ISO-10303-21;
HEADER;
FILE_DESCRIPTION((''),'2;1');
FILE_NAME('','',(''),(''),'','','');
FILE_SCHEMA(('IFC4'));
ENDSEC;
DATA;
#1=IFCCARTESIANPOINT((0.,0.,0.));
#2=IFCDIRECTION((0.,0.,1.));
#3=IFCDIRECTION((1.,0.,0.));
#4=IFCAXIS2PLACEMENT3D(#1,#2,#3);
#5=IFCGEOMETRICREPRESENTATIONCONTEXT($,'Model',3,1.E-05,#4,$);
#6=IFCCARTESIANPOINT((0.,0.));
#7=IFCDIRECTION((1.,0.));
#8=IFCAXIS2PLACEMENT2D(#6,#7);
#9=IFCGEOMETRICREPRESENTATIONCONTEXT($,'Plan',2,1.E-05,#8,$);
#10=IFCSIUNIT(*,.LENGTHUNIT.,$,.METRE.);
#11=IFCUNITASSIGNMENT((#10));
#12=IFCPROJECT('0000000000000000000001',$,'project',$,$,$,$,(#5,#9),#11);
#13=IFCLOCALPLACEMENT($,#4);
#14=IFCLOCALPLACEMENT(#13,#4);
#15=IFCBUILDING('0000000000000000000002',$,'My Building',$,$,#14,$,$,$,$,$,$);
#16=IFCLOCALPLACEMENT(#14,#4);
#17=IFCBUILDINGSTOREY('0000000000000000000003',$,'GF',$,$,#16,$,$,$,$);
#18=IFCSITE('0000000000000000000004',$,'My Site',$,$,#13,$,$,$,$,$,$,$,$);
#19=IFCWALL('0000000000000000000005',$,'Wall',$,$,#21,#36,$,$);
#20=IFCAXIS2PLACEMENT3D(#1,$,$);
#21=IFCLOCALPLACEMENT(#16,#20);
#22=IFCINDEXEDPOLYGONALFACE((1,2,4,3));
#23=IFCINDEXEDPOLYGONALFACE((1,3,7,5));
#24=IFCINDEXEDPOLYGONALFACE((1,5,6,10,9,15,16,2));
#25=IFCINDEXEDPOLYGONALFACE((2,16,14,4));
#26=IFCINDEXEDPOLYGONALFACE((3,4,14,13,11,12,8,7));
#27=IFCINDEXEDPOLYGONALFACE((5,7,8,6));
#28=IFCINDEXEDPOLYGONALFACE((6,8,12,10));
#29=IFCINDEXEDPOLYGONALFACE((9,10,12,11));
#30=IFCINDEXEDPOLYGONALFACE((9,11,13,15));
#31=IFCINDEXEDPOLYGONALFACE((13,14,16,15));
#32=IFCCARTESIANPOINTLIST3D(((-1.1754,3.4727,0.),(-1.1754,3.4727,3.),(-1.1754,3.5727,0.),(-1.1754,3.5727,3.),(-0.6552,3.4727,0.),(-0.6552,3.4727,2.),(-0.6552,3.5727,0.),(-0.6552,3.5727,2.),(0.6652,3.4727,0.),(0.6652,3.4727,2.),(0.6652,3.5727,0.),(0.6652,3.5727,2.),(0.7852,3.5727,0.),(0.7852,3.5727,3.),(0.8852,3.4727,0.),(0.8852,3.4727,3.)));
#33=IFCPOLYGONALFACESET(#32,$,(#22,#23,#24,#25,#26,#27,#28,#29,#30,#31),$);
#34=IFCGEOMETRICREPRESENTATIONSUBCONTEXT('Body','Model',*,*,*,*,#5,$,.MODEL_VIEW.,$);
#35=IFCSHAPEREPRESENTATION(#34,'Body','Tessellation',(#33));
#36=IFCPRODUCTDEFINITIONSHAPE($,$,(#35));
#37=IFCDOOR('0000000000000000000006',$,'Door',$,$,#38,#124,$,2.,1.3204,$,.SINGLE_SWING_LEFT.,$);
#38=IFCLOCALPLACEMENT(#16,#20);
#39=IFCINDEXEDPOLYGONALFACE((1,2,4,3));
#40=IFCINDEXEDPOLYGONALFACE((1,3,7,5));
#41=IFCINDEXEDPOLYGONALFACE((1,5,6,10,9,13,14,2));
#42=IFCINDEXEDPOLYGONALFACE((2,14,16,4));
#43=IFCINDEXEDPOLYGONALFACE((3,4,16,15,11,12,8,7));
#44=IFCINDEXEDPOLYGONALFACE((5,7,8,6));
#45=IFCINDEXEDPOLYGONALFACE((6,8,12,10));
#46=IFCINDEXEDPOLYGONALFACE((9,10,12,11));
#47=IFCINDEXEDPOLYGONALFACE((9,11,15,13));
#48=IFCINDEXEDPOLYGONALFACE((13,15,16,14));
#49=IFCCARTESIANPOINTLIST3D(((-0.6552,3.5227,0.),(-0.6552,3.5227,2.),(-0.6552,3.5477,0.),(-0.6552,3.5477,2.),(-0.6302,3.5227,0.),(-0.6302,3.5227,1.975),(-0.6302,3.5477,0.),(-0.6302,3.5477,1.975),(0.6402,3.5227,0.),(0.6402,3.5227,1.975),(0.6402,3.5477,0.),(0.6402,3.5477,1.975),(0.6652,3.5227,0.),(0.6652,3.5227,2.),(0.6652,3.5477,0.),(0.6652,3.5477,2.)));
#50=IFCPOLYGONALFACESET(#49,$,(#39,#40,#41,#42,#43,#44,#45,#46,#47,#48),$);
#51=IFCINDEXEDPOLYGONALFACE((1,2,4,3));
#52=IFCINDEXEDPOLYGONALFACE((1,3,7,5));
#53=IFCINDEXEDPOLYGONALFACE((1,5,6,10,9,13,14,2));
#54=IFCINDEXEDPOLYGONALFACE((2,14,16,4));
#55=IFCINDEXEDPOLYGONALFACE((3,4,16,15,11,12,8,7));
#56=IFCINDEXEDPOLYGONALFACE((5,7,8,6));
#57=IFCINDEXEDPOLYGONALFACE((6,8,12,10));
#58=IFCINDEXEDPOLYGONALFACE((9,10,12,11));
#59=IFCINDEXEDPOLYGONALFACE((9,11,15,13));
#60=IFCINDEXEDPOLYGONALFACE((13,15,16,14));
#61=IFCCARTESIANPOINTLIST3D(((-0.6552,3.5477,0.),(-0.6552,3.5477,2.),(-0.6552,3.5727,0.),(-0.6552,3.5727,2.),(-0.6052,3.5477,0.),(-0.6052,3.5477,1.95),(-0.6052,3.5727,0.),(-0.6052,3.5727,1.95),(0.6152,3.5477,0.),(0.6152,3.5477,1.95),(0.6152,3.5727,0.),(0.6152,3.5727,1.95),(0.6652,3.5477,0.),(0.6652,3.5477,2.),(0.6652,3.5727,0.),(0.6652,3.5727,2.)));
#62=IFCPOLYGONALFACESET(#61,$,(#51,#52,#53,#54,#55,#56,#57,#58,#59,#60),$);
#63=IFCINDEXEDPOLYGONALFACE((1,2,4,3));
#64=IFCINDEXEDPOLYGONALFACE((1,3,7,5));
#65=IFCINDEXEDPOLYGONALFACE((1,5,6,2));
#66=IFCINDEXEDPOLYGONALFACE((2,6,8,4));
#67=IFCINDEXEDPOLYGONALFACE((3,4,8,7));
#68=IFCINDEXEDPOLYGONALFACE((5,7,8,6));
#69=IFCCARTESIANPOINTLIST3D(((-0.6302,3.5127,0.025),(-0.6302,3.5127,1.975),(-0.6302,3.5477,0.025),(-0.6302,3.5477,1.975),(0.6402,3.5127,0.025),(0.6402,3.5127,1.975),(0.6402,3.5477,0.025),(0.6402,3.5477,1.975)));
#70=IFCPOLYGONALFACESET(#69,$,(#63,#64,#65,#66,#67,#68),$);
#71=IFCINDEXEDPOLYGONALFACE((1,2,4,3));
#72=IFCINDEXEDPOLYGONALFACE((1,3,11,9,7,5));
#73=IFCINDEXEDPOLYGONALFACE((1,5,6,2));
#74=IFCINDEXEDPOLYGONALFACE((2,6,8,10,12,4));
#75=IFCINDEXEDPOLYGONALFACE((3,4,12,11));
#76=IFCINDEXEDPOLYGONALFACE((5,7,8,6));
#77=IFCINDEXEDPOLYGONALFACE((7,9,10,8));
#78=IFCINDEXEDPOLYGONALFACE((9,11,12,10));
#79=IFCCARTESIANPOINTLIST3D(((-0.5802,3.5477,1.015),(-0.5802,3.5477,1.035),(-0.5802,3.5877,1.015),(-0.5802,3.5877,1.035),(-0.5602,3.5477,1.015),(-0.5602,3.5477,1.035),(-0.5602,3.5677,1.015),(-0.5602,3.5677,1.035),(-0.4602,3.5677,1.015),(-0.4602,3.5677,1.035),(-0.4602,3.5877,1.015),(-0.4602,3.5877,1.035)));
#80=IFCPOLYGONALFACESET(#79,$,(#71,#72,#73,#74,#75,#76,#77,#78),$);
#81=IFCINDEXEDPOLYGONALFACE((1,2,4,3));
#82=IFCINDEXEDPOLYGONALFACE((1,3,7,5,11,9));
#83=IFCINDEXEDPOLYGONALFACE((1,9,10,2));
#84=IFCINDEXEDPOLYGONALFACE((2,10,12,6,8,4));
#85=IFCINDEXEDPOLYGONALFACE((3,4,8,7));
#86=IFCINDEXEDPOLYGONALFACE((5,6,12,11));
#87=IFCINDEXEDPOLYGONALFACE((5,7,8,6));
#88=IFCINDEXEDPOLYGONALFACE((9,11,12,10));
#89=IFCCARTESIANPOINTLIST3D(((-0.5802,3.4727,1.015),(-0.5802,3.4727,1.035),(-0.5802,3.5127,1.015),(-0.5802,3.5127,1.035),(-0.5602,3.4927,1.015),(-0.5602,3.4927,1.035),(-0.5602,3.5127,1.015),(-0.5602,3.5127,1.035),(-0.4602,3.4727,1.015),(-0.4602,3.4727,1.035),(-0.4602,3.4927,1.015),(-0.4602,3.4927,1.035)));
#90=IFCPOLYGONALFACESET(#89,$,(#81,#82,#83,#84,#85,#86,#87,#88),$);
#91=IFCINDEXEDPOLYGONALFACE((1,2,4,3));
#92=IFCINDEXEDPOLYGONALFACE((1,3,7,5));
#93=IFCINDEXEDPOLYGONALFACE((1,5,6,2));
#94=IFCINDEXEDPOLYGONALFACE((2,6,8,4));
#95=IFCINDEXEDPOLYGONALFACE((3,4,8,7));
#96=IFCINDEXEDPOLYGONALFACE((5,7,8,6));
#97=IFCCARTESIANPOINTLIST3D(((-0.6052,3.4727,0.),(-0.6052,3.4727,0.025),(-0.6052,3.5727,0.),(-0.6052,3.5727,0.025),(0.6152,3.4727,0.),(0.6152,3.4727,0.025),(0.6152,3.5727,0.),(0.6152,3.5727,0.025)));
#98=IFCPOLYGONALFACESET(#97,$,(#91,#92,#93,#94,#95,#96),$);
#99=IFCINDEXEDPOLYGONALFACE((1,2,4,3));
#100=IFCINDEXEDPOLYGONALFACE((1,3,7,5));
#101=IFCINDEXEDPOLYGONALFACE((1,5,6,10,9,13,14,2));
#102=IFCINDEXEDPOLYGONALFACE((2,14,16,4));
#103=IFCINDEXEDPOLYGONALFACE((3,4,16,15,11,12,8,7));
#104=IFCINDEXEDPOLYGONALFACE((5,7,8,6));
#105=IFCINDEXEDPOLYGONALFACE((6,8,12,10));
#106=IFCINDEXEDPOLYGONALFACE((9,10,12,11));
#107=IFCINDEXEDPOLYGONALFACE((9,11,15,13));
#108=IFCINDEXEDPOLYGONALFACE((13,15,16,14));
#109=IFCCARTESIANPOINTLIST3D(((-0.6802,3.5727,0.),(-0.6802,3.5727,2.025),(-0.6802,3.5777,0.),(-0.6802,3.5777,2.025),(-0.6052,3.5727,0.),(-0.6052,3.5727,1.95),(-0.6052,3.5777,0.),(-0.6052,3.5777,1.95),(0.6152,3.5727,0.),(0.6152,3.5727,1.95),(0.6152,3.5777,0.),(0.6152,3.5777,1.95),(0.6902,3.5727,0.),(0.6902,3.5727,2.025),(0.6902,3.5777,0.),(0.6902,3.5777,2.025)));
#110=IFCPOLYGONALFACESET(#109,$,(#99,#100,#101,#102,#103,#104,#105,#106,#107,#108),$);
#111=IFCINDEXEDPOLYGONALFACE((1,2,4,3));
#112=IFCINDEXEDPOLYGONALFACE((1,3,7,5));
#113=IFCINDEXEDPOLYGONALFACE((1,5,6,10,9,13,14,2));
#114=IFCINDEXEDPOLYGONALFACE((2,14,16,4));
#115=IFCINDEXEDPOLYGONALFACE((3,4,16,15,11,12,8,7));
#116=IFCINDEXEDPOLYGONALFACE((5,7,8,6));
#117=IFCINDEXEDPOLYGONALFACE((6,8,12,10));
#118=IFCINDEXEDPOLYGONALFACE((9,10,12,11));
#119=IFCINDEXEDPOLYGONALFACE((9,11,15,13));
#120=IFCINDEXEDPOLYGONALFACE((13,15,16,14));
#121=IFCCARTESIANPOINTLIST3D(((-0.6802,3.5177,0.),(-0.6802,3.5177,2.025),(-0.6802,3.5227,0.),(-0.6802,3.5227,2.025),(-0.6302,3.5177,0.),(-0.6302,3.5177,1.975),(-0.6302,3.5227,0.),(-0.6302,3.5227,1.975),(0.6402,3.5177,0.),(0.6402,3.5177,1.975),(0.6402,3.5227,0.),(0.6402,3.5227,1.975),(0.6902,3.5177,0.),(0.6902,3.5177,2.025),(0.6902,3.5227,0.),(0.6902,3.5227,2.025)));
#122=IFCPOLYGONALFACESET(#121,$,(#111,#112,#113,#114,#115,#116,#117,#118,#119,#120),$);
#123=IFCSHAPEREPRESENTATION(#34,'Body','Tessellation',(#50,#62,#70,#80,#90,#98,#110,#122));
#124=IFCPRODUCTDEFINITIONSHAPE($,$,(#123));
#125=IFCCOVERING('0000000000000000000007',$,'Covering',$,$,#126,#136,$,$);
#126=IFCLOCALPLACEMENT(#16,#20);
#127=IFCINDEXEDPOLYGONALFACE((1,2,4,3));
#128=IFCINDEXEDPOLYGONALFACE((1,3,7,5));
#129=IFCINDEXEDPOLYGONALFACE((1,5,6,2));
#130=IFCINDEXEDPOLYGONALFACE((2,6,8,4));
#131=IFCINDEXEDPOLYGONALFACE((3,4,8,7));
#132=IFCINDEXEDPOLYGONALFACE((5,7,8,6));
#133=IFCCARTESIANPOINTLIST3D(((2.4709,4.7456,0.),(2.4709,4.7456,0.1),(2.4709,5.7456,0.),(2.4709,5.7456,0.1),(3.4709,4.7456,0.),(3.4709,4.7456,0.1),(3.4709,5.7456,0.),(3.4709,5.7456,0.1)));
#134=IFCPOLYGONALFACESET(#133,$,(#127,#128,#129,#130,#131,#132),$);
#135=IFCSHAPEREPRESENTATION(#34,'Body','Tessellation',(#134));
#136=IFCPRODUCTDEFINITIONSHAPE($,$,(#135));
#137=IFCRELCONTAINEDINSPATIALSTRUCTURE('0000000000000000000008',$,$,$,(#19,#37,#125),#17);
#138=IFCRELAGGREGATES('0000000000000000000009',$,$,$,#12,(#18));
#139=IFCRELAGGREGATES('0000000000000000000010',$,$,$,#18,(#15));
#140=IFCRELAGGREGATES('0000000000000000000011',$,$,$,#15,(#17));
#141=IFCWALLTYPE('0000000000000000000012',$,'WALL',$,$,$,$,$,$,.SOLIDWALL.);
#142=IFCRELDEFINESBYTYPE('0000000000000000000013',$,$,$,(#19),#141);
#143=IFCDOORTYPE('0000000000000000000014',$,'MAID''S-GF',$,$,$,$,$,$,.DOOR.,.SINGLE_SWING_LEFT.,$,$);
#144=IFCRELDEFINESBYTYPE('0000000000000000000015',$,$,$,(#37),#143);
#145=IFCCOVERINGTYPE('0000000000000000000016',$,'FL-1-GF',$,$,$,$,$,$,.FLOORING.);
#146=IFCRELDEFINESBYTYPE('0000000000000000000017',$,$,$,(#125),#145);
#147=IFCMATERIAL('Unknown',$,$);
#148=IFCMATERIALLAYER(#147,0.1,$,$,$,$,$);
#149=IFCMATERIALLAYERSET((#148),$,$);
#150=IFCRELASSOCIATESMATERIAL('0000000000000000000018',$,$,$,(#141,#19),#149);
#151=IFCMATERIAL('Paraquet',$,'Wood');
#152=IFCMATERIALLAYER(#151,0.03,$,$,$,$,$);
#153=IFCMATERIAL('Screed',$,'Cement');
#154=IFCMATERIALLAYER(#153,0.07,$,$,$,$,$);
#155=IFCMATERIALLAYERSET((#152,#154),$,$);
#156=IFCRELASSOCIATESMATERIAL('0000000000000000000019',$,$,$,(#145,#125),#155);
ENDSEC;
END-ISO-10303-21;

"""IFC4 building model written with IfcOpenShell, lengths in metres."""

from ifc_helpers import new_model, entity, si_unit, frame, origin_with_axes, origin_2d_with_axis, place, context, subcontext, project, spatial, line, indexed_curve, outline, extrude, shape, source, transform, mapped, material, layer, layer_set, layer_usage, type_object, type_shapes, element, fill, save


model = new_model("IFC4")

# Units and contexts
model_context = context("Model", 3, precision=1e-05, world=origin_with_axes())
plan_context = context("Plan", 2, precision=1e-05, world=origin_2d_with_axis())
body_context_1 = subcontext(model_context, "Body", "Model", "MODEL_VIEW")
body_context_2 = subcontext(plan_context, "Body", "Plan", "PLAN_VIEW")
ifc_project = project(units=[si_unit("LENGTHUNIT", "METRE")], contexts=[model_context, plan_context])

# Site, building, storey
site_placement = place(None, origin_with_axes())
site = spatial("IfcSite", under=ifc_project, at=site_placement, Name="My Site")
building_placement = place(site_placement, origin_with_axes())
building = spatial("IfcBuilding", under=site, at=building_placement, Name="My Building")
storey_placement = place(building_placement, origin_with_axes())
storey = spatial("IfcBuildingStorey", under=building, at=storey_placement, Name="GF")

# Shared definitions
ifc_material_1 = material(Name="Unknown")

# Shared definitions
ifc_layer_1 = layer(ifc_material_1, 0.1)
ifc_layer_set_1 = layer_set([ifc_layer_1])
wall_type = type_object("IfcWallType", Name="WALL", PredefinedType="SOLIDWALL", material=ifc_layer_set_1)

# Wall, opening, door
ifc_layer_usage_1 = layer_usage(ifc_layer_set_1, "AXIS2", "POSITIVE", 0.0)
wall_1_placement = place(storey_placement, frame((0.7852, 3.5727, 0.0), z_axis=(0.0, 0.0, 1.0), x_axis=(-1.0, 0.0, 0.0)))
wall_1 = element("IfcWall", 1, at=wall_1_placement, inside=storey, type_object=wall_type, material=ifc_layer_usage_1, Name="Wall", context=body_context_1, shape_type="SweptSolid", body=[
    extrude(outline(indexed_curve([(0.0, 0.0), (-0.1, 0.1), (1.9606, 0.1), (1.9606, 0.0)], segments=[line(1, 2, 3, 4, 1)])), origin_with_axes(), (0.0, 0.0, 1.0), 3.0),
])
shared_shape_1 = source(origin_with_axes(), body_context_1, "Body", "SweptSolid", [
    extrude(outline(indexed_curve([(0.0, 0.0), (1.3204, 0.0), (1.3204, 2.0), (0.0, 2.0)], segments=[line(1, 2, 3, 4, 1)])), frame((0.0, -0.6, 0.0), z_axis=(0.0, -1.0, 0.0), x_axis=(1.0, 0.0, 0.0)), (0.0, 0.0, -1.0), 1.2),
])
opening_1_placement = place(wall_1_placement, frame((0.12, 0.0, 0.0), z_axis=(0.0, 0.0, 1.0), x_axis=(1.0, 0.0, 0.0)))
opening_1 = element("IfcOpeningElement", 2, at=opening_1_placement, cuts=wall_1, PredefinedType="OPENING", context=body_context_1, shape_type="MappedRepresentation", body=[
    mapped(shared_shape_1, transform((0.0, 0.0, 0.0), x_axis=(1.0, 0.0, 0.0), y_axis=(0.0, 1.0, 0.0), z_axis=(0.0, 0.0, 1.0), scale=1.0)),
])
door_type_1 = type_object("IfcDoorType", Name="MAID'S-GF", OperationType="SINGLE_SWING_LEFT", PredefinedType="DOOR")
shared_shape_2 = source(origin_with_axes(), body_context_1, "Body", "SweptSolid", [
    extrude(outline(indexed_curve([(0.0, 0.0), (0.0, 2.0), (1.3204, 2.0), (1.3204, 0.0), (1.2954, 0.0), (1.2954, 1.975), (0.025, 1.975), (0.025, 0.0)], segments=[line(1, 2, 3, 4, 5, 6, 7, 8, 1)])), frame((0.0, 0.025, 0.0), z_axis=(0.0, -1.0, 0.0), x_axis=(1.0, 0.0, 0.0)), (0.0, 0.0, -1.0), 0.025),
    extrude(outline(indexed_curve([(0.0, 0.0), (0.0, 2.0), (1.3204, 2.0), (1.3204, 0.0), (1.2704, 0.0), (1.2704, 1.95), (0.05, 1.95), (0.05, 0.0)], segments=[line(1, 2, 3, 4, 5, 6, 7, 8, 1)])), frame((0.0, 0.0, 0.0), z_axis=(0.0, -1.0, 0.0), x_axis=(1.0, 0.0, 0.0)), (0.0, 0.0, -1.0), 0.025),
    extrude(outline(indexed_curve([(0.0, 0.0), (1.2704, 0.0), (1.2704, 0.035), (0.0, 0.035)], segments=[line(1, 2, 3, 4, 1)])), frame((0.025, 0.025, 0.025), z_axis=(0.0, 0.0, 1.0), x_axis=(1.0, 0.0, 0.0)), (0.0, 0.0, 1.0), 1.95),
    extrude(outline(indexed_curve([(0.0, 0.0), (0.0, -0.04), (-0.12, -0.04), (-0.12, -0.02), (-0.02, -0.02), (-0.02, 0.0)], segments=[line(1, 2, 3, 4, 5, 6, 1)])), frame((1.2454, 0.025, 1.015), z_axis=(0.0, 0.0, 1.0), x_axis=(1.0, 0.0, 0.0)), (0.0, 0.0, 1.0), 0.02),
    extrude(outline(indexed_curve([(0.0, 0.0), (0.0, 0.04), (-0.12, 0.04), (-0.12, 0.02), (-0.02, 0.02), (-0.02, 0.0)], segments=[line(1, 2, 3, 4, 5, 6, 1)])), frame((1.2454, 0.06, 1.015), z_axis=(0.0, 0.0, 1.0), x_axis=(1.0, 0.0, 0.0)), (0.0, 0.0, 1.0), 0.02),
    extrude(outline(indexed_curve([(0.0, 0.0), (1.2204, 0.0), (1.2204, 0.1), (0.0, 0.1)], segments=[line(1, 2, 3, 4, 1)])), frame((0.05, 0.0, 0.0), z_axis=(0.0, 0.0, 1.0), x_axis=(1.0, 0.0, 0.0)), (0.0, 0.0, 1.0), 0.025),
    extrude(outline(indexed_curve([(0.0, 0.0), (0.0, 2.025), (1.3704, 2.025), (1.3704, 0.0), (1.2954, 0.0), (1.2954, 1.95), (0.075, 1.95), (0.075, 0.0)], segments=[line(1, 2, 3, 4, 5, 6, 7, 8, 1)])), frame((-0.025, -0.005, 0.0), z_axis=(0.0, -1.0, 0.0), x_axis=(1.0, 0.0, 0.0)), (0.0, 0.0, -1.0), 0.005),
    extrude(outline(indexed_curve([(0.0, 0.0), (0.0, 2.025), (1.3704, 2.025), (1.3704, 0.0), (1.3204, 0.0), (1.3204, 1.975), (0.05, 1.975), (0.05, 0.0)], segments=[line(1, 2, 3, 4, 5, 6, 7, 8, 1)])), frame((-0.025, 0.05, 0.0), z_axis=(0.0, -1.0, 0.0), x_axis=(1.0, 0.0, 0.0)), (0.0, 0.0, -1.0), 0.005),
])
shared_shape_3 = source(origin_with_axes(), body_context_2, "Body", "Curve2D", [
    entity("IfcIndexedPolyCurve", entity("IfcCartesianPointList2D", [[0.0, 0.0], [0.0, 0.05], [0.025, 0.05], [0.025, 0.025], [0.05, 0.025], [0.05, 0.0]]), [entity("IfcLineIndex", [1, 2, 3, 4, 5, 6, 1])]),
    entity("IfcIndexedPolyCurve", entity("IfcCartesianPointList2D", [[1.3204, 0.0], [1.3204, 0.05], [1.2954, 0.05], [1.2954, 0.025], [1.2704, 0.025], [1.2704, 0.0]]), [entity("IfcLineIndex", [1, 2, 3, 4, 5, 6, 1])]),
    entity("IfcTrimmedCurve", entity("IfcEllipse", entity("IfcAxis2Placement2D", entity("IfcCartesianPoint", [0.06, 0.05]), entity("IfcDirection", [1.0, 0.0])), 1.2354, 1.2704), [entity("IfcCartesianPoint", [1.2954, 0.05])], [entity("IfcCartesianPoint", [0.06, 1.3204])], True, "CARTESIAN"),
    entity("IfcIndexedPolyCurve", entity("IfcCartesianPointList2D", [[0.025, 0.05], [0.06, 0.05], [0.06, 1.3204], [0.025, 1.3204]]), [entity("IfcLineIndex", [1, 2, 3, 4, 1])]),
])
type_shapes(door_type_1, [shared_shape_2, shared_shape_3])
door_1_placement = place(opening_1_placement, frame((0.0, 0.0, 0.0), z_axis=(0.0, 0.0, 1.0), x_axis=(1.0, 0.0, 0.0)))
door_1 = element("IfcDoor", 3, at=door_1_placement, inside=storey, type_object=door_type_1, Name="Door", OperationType="SINGLE_SWING_LEFT", OverallHeight=2.0, OverallWidth=1.3204, shapes=[
    shape(body_context_1, "Body", "MappedRepresentation", [mapped(shared_shape_2, transform((0.0, 0.0, 0.0), x_axis=(1.0, 0.0, 0.0), y_axis=(0.0, 1.0, 0.0), z_axis=(0.0, 0.0, 1.0), scale=1.0))]),
    shape(body_context_2, "Body", "MappedRepresentation", [mapped(shared_shape_3, transform((0.0, 0.0, 0.0), x_axis=(1.0, 0.0, 0.0), y_axis=(0.0, 1.0, 0.0), z_axis=(0.0, 0.0, 1.0), scale=1.0))]),
])
fill(opening_1, door_1)

# Covering
ifc_material_2 = material(Name="Paraquet", Category="Wood")
ifc_layer_2 = layer(ifc_material_2, 0.03)
ifc_material_3 = material(Name="Screed", Category="Cement")
ifc_layer_3 = layer(ifc_material_3, 0.07)
ifc_layer_set_2 = layer_set([ifc_layer_2, ifc_layer_3])
ifc_layer_usage_2 = layer_usage(ifc_layer_set_2, "AXIS3", "POSITIVE", 0.0)
covering_type = type_object("IfcCoveringType", Name="FL-1-GF", PredefinedType="FLOORING", material=ifc_layer_set_2)
covering_placement = place(storey_placement, frame((2.4709, 4.7456, 0.0), z_axis=(0.0, 0.0, 1.0), x_axis=(1.0, 0.0, 0.0)))
element("IfcCovering", 4, at=covering_placement, inside=storey, type_object=covering_type, material=ifc_layer_usage_2, Name="Covering", context=body_context_1, shape_type="SweptSolid", body=[
    extrude(outline(indexed_curve([(0.0, 0.0), (1.0, 0.0), (1.0, 1.0), (0.0, 1.0), (0.0, 0.0)])), origin_with_axes(), (0.0, 0.0, 1.0), 0.1),
])

save(model, "model.ifc")
